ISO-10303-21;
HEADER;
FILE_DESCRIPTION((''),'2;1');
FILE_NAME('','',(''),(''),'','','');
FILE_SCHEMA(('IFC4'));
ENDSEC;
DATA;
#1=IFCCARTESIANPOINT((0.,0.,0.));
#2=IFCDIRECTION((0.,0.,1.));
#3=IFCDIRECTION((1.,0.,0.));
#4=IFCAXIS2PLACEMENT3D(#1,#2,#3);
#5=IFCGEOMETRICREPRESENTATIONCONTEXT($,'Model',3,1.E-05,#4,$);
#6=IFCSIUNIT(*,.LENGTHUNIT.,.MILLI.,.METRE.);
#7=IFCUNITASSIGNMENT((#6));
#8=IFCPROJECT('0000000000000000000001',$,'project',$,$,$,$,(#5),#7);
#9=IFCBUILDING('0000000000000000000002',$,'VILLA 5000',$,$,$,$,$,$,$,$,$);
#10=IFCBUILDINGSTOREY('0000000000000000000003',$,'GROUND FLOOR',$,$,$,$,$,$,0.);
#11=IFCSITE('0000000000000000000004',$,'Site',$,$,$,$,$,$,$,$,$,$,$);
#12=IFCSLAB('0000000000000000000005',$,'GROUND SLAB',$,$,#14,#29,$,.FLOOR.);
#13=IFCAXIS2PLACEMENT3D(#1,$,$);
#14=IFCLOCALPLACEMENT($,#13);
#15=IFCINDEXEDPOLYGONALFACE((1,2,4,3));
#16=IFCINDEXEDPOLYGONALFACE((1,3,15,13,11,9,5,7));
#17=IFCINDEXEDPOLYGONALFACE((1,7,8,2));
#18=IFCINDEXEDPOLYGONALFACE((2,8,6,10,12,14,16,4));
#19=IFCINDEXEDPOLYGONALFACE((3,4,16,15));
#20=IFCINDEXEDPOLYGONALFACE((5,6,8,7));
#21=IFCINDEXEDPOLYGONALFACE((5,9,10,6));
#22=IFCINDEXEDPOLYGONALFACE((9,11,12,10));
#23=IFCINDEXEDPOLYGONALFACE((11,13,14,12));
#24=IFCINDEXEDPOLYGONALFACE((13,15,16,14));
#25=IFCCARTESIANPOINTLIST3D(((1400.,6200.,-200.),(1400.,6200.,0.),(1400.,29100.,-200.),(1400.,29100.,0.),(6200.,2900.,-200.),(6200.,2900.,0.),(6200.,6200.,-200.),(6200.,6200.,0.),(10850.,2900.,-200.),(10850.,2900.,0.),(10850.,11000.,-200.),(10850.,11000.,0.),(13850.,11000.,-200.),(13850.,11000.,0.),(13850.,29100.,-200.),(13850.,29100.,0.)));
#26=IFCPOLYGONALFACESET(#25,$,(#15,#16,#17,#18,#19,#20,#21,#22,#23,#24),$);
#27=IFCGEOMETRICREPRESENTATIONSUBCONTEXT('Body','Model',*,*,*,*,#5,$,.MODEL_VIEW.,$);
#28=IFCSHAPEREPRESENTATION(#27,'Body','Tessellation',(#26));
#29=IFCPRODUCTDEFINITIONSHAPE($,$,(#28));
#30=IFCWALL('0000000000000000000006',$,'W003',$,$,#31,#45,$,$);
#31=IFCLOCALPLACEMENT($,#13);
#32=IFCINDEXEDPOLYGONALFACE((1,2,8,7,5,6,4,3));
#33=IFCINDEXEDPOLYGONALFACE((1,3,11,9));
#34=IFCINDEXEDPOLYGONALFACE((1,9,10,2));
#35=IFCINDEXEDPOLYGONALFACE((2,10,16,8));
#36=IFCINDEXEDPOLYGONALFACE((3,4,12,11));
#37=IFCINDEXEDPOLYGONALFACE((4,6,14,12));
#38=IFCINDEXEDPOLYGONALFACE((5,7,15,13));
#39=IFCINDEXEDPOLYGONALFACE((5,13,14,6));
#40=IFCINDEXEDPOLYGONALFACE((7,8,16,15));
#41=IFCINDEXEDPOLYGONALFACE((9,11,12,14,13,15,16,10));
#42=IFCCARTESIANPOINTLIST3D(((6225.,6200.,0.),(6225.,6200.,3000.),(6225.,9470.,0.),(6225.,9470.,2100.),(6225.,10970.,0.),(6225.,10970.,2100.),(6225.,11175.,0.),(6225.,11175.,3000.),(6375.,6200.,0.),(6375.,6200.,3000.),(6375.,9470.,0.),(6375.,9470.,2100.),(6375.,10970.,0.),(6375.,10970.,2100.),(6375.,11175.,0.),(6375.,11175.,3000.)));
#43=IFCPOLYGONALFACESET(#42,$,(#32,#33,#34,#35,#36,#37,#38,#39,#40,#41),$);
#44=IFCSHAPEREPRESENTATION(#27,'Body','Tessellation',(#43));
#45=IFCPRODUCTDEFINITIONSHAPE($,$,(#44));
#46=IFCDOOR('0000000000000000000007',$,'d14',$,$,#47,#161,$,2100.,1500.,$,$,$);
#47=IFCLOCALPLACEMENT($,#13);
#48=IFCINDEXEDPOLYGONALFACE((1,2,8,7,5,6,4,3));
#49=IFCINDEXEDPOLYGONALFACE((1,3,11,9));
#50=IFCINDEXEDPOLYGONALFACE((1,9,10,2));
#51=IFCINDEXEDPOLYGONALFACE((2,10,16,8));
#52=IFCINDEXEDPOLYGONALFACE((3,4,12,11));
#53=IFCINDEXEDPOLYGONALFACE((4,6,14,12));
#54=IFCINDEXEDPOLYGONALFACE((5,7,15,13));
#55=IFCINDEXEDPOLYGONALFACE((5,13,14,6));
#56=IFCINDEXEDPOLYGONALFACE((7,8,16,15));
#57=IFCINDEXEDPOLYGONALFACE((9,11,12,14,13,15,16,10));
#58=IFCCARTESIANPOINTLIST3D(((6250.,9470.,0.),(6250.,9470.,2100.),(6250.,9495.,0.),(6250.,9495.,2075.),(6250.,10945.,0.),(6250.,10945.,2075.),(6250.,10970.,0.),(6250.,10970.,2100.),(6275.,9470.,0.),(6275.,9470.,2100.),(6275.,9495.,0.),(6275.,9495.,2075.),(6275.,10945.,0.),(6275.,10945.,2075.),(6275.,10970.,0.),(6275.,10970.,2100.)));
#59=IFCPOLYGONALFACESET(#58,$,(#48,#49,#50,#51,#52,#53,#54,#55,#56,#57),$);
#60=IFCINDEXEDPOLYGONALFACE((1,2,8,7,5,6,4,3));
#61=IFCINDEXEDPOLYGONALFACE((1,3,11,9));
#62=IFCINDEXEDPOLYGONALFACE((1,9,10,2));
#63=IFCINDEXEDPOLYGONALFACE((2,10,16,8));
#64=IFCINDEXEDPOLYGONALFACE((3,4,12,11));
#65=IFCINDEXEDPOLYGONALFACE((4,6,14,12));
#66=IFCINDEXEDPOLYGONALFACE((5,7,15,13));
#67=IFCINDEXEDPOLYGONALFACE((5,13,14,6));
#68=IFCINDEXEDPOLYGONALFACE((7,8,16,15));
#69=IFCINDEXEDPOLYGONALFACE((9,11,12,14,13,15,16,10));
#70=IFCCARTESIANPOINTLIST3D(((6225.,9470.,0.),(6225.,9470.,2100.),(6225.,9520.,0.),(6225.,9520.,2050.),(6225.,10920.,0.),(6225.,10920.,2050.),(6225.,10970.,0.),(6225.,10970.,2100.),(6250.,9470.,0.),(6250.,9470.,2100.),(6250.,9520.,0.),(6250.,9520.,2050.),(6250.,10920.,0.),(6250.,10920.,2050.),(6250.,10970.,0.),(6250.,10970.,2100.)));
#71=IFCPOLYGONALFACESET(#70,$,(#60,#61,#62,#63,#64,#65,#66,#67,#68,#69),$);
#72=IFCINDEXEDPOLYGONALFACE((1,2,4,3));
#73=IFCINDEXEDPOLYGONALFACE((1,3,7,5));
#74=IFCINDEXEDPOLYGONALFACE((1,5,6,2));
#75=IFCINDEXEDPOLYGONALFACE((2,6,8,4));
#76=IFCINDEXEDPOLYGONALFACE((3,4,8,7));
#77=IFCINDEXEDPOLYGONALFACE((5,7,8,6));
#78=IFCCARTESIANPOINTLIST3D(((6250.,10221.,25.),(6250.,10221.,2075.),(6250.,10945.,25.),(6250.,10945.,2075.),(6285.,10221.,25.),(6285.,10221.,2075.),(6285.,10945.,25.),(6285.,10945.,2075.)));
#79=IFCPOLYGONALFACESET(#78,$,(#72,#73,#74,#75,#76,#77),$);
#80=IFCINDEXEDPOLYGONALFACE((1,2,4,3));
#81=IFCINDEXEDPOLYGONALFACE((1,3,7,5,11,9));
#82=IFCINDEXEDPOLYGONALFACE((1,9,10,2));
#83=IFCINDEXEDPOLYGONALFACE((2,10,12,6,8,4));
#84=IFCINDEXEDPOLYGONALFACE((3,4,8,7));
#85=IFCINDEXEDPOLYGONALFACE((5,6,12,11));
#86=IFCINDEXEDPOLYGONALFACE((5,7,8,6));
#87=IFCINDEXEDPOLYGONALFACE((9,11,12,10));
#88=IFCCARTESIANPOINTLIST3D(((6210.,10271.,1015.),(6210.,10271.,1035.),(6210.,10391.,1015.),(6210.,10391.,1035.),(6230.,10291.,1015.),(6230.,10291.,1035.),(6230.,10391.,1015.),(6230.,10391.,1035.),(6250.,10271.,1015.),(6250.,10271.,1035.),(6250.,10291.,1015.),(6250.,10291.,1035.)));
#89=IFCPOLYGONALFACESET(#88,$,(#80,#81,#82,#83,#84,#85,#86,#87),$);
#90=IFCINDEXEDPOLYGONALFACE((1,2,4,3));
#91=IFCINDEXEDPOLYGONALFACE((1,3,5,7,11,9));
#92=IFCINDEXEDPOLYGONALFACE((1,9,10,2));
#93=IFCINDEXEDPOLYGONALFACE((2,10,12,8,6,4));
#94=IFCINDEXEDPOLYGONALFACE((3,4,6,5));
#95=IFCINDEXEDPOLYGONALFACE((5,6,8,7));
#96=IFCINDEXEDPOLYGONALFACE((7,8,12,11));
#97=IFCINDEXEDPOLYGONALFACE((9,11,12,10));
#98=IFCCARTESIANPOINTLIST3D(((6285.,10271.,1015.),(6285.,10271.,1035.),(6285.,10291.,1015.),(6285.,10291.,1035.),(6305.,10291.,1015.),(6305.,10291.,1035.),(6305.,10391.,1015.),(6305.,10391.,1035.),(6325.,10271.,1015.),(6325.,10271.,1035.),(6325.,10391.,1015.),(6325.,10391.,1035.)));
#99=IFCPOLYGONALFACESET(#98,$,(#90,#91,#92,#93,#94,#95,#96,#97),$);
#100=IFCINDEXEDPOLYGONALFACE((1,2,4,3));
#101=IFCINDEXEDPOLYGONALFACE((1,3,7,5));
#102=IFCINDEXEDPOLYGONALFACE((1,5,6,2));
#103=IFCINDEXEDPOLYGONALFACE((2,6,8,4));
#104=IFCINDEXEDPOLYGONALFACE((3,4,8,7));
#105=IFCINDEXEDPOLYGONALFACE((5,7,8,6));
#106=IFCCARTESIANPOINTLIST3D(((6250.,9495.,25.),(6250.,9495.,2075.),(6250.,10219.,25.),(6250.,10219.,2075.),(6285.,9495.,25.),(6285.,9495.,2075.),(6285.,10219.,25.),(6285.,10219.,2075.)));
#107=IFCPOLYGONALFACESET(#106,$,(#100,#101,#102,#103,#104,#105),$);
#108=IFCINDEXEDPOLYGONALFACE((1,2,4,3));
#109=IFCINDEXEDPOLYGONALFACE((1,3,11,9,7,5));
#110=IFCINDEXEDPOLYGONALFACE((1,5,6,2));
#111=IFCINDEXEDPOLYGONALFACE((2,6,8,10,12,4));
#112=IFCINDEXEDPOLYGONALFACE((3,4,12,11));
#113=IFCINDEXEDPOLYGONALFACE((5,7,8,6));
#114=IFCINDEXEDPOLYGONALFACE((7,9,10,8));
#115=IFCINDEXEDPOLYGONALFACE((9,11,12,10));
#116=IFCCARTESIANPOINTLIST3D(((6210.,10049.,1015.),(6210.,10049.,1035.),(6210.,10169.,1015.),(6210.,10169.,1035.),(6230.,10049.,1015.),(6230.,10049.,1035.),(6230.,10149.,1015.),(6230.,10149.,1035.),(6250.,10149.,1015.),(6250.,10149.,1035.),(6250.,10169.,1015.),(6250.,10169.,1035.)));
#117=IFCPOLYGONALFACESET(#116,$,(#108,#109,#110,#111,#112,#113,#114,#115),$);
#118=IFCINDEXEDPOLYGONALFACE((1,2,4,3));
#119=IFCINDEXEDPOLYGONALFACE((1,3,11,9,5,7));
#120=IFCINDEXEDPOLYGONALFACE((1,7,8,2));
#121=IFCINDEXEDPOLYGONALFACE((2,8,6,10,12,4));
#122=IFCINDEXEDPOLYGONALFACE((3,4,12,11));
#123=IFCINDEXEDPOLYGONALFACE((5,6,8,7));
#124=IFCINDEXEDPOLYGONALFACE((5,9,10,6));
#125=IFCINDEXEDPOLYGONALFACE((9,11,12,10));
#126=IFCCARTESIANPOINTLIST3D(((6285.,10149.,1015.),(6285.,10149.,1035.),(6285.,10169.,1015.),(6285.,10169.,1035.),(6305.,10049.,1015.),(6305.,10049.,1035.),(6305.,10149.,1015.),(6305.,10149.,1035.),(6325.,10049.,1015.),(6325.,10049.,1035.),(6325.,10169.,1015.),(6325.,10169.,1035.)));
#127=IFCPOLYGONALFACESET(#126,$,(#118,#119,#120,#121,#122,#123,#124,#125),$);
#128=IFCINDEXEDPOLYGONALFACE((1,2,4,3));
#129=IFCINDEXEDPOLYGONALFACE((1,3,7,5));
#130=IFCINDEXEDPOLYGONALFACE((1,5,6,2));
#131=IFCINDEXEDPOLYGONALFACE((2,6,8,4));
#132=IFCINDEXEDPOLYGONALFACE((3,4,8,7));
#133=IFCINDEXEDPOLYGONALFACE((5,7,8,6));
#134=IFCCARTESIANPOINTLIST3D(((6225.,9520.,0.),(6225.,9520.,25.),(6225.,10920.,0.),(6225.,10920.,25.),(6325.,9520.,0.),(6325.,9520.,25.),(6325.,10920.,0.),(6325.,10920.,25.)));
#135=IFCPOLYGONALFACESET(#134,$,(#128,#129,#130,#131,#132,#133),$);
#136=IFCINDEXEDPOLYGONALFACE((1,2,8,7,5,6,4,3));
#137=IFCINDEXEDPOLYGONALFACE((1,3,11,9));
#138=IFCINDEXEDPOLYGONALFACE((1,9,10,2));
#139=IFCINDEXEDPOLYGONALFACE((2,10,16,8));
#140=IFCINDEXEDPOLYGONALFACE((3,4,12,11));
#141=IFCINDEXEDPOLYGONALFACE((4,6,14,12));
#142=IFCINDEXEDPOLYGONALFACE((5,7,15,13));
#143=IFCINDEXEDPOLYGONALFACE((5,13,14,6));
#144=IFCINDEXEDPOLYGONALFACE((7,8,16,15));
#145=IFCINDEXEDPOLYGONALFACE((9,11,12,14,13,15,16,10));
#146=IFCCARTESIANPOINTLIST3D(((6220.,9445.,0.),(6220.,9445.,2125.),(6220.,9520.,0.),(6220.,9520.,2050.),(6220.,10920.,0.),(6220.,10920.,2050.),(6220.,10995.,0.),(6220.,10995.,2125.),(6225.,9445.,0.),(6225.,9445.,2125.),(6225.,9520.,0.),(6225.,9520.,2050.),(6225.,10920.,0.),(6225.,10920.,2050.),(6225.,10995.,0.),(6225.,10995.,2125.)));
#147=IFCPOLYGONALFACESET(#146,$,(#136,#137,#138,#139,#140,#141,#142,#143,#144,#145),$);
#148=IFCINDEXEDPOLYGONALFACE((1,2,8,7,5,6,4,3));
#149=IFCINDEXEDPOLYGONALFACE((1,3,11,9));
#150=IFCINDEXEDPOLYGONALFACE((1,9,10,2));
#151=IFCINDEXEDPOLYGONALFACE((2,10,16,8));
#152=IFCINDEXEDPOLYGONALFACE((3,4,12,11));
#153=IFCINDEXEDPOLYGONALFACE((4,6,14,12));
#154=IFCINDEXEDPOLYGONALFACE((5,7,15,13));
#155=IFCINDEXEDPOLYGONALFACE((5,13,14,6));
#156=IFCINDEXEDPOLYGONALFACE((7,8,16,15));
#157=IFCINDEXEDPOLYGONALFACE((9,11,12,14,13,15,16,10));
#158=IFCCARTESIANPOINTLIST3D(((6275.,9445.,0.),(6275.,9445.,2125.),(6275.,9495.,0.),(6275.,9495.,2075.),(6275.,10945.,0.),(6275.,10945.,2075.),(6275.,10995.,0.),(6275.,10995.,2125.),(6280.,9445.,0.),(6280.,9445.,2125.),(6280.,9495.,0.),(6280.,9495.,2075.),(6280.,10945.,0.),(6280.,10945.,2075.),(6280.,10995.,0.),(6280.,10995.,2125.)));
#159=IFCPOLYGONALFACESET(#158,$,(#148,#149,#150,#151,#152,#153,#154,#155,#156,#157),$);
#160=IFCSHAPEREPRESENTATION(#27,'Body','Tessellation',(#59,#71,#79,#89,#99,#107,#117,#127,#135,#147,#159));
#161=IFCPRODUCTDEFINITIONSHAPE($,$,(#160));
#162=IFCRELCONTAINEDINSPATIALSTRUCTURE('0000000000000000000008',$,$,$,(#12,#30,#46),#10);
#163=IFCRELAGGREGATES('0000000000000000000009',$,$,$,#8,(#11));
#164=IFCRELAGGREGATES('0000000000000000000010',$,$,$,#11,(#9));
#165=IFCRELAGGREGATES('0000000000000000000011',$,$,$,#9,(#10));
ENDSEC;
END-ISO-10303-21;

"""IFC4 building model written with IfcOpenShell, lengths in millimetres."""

from ifc_helpers import new_model, si_unit, frame, origin_with_axes, place, context, subcontext, project, spatial, line, indexed_curve, outline, extrude, element, fill, save


model = new_model("IFC4")

# Units and contexts
model_context = context("Model", 3, precision=1e-05, world=origin_with_axes())
body_context = subcontext(model_context, "Body", "Model", "MODEL_VIEW")
ifc_project = project(units=[si_unit("LENGTHUNIT", "METRE", prefix="MILLI")], contexts=[model_context])

# Site, building, storey
site = spatial("IfcSite", under=ifc_project, Name="Site")
building = spatial("IfcBuilding", under=site, Name="VILLA 5000")
storey = spatial("IfcBuildingStorey", under=building, Name="GROUND FLOOR", Elevation=0.0)

# Slab
slab_placement = place(None, frame((0.0, 0.0, -200.0), z_axis=(0.0, 0.0, 1.0), x_axis=(1.0, 0.0, 0.0)))
element("IfcSlab", 1, at=slab_placement, inside=storey, Name="GROUND SLAB", PredefinedType="FLOOR", context=body_context, shape_type="SweptSolid", body=[
    extrude(outline(indexed_curve([(1400.0, 6200.0), (6200.0, 6200.0), (6200.0, 2900.0), (10850.0, 2900.0), (10850.0, 11000.0), (13850.0, 11000.0), (13850.0, 29100.0), (1400.0, 29100.0)])), None, (0.0, 0.0, 1.0), 200.0),
])

# Wall, opening, door
wall_1_placement = place(None, frame((6300.0, 11175.0, 0.0), z_axis=(0.0, 0.0, 1.0), x_axis=(0.0, -1.0, 0.0)))
wall_1 = element("IfcWall", 2, at=wall_1_placement, inside=storey, Name="W003", context=body_context, shape_type="SweptSolid", body=[
    extrude(outline(indexed_curve([(0.0, 0.0), (0.0, 150.0), (4975.0, 150.0), (4975.0, 0.0), (0.0, 0.0)], self_intersect=False)), frame((0.0, -75.0, 0.0), z_axis=(0.0, 0.0, 1.0), x_axis=(1.0, 0.0, 0.0)), (0.0, 0.0, 1.0), 3000.0),
])
opening_1_placement = place(wall_1_placement, frame((205.0, 0.0, 0.0), z_axis=(0.0, 0.0, 1.0), x_axis=(1.0, 0.0, 0.0)))
opening_1 = element("IfcOpeningElement", 3, at=opening_1_placement, cuts=wall_1, context=body_context, shape_type="SweptSolid", body=[
    extrude(outline(indexed_curve([(0.0, 0.0), (0.0, 250.0), (1500.0, 250.0), (1500.0, 0.0), (0.0, 0.0)], self_intersect=False)), frame((0.0, -125.0, 0.0), z_axis=(0.0, 0.0, 1.0), x_axis=(1.0, 0.0, 0.0)), (0.0, 0.0, 1.0), 2100.0),
])
door_1_placement = place(None, frame((6225.0, 10970.0, 0.0), z_axis=(0.0, 0.0, 1.0), x_axis=(0.0, -1.0, 0.0)))
door_1 = element("IfcDoor", 4, at=door_1_placement, inside=storey, Name="d14", OverallHeight=2100.0, OverallWidth=1500.0, context=body_context, shape_type="SweptSolid", body=[
    extrude(outline(indexed_curve([(0.0, 0.0), (0.0, 2100.0), (1500.0, 2100.0), (1500.0, 0.0), (1475.0, 0.0), (1475.0, 2075.0), (25.0, 2075.0), (25.0, 0.0)], segments=[line(1, 2, 3, 4, 5, 6, 7, 8, 1)])), frame((0.0, 25.0, 0.0), z_axis=(0.0, -1.0, 0.0), x_axis=(1.0, 0.0, 0.0)), (0.0, 0.0, -1.0), 25.0),
    extrude(outline(indexed_curve([(0.0, 0.0), (0.0, 2100.0), (1500.0, 2100.0), (1500.0, 0.0), (1450.0, 0.0), (1450.0, 2050.0), (50.0, 2050.0), (50.0, 0.0)], segments=[line(1, 2, 3, 4, 5, 6, 7, 8, 1)])), frame((0.0, 0.0, 0.0), z_axis=(0.0, -1.0, 0.0), x_axis=(1.0, 0.0, 0.0)), (0.0, 0.0, -1.0), 25.0),
    extrude(outline(indexed_curve([(0.0, 0.0), (724.0, 0.0), (724.0, 35.0), (0.0, 35.0)], segments=[line(1, 2, 3, 4, 1)])), frame((25.0, 25.0, 25.0), z_axis=(0.0, 0.0, 1.0), x_axis=(1.0, 0.0, 0.0)), (0.0, 0.0, 1.0), 2050.0),
    extrude(outline(indexed_curve([(0.0, 0.0), (0.0, -40.0), (-120.0, -40.0), (-120.0, -20.0), (-20.0, -20.0), (-20.0, 0.0)], segments=[line(1, 2, 3, 4, 5, 6, 1)])), frame((699.0, 25.0, 1015.0), z_axis=(0.0, 0.0, 1.0), x_axis=(1.0, 0.0, 0.0)), (0.0, 0.0, 1.0), 20.0),
    extrude(outline(indexed_curve([(0.0, 0.0), (0.0, 40.0), (-120.0, 40.0), (-120.0, 20.0), (-20.0, 20.0), (-20.0, 0.0)], segments=[line(1, 2, 3, 4, 5, 6, 1)])), frame((699.0, 60.0, 1015.0), z_axis=(0.0, 0.0, 1.0), x_axis=(1.0, 0.0, 0.0)), (0.0, 0.0, 1.0), 20.0),
    extrude(outline(indexed_curve([(0.0, 0.0), (-724.0, 0.0), (-724.0, 35.0), (0.0, 35.0)], segments=[line(1, 2, 3, 4, 1)])), frame((1475.0, 25.0, 25.0), z_axis=(0.0, 0.0, 1.0), x_axis=(1.0, 0.0, 0.0)), (0.0, 0.0, 1.0), 2050.0),
    extrude(outline(indexed_curve([(0.0, 0.0), (0.0, -40.0), (120.0, -40.0), (120.0, -20.0), (20.0, -20.0), (20.0, 0.0)], segments=[line(1, 2, 3, 4, 5, 6, 1)])), frame((801.0, 25.0, 1015.0), z_axis=(0.0, 0.0, 1.0), x_axis=(1.0, 0.0, 0.0)), (0.0, 0.0, 1.0), 20.0),
    extrude(outline(indexed_curve([(0.0, 0.0), (0.0, 40.0), (120.0, 40.0), (120.0, 20.0), (20.0, 20.0), (20.0, 0.0)], segments=[line(1, 2, 3, 4, 5, 6, 1)])), frame((801.0, 60.0, 1015.0), z_axis=(0.0, 0.0, 1.0), x_axis=(1.0, 0.0, 0.0)), (0.0, 0.0, 1.0), 20.0),
    extrude(outline(indexed_curve([(0.0, 0.0), (1400.0, 0.0), (1400.0, 100.0), (0.0, 100.0)], segments=[line(1, 2, 3, 4, 1)])), frame((50.0, 0.0, 0.0), z_axis=(0.0, 0.0, 1.0), x_axis=(1.0, 0.0, 0.0)), (0.0, 0.0, 1.0), 25.0),
    extrude(outline(indexed_curve([(0.0, 0.0), (0.0, 2125.0), (1550.0, 2125.0), (1550.0, 0.0), (1475.0, 0.0), (1475.0, 2050.0), (75.0, 2050.0), (75.0, 0.0)], segments=[line(1, 2, 3, 4, 5, 6, 7, 8, 1)])), frame((-25.0, -5.0, 0.0), z_axis=(0.0, -1.0, 0.0), x_axis=(1.0, 0.0, 0.0)), (0.0, 0.0, -1.0), 5.0),
    extrude(outline(indexed_curve([(0.0, 0.0), (0.0, 2125.0), (1550.0, 2125.0), (1550.0, 0.0), (1500.0, 0.0), (1500.0, 2075.0), (50.0, 2075.0), (50.0, 0.0)], segments=[line(1, 2, 3, 4, 5, 6, 7, 8, 1)])), frame((-25.0, 50.0, 0.0), z_axis=(0.0, -1.0, 0.0), x_axis=(1.0, 0.0, 0.0)), (0.0, 0.0, -1.0), 5.0),
])
fill(opening_1, door_1)

save(model, "model.ifc")
